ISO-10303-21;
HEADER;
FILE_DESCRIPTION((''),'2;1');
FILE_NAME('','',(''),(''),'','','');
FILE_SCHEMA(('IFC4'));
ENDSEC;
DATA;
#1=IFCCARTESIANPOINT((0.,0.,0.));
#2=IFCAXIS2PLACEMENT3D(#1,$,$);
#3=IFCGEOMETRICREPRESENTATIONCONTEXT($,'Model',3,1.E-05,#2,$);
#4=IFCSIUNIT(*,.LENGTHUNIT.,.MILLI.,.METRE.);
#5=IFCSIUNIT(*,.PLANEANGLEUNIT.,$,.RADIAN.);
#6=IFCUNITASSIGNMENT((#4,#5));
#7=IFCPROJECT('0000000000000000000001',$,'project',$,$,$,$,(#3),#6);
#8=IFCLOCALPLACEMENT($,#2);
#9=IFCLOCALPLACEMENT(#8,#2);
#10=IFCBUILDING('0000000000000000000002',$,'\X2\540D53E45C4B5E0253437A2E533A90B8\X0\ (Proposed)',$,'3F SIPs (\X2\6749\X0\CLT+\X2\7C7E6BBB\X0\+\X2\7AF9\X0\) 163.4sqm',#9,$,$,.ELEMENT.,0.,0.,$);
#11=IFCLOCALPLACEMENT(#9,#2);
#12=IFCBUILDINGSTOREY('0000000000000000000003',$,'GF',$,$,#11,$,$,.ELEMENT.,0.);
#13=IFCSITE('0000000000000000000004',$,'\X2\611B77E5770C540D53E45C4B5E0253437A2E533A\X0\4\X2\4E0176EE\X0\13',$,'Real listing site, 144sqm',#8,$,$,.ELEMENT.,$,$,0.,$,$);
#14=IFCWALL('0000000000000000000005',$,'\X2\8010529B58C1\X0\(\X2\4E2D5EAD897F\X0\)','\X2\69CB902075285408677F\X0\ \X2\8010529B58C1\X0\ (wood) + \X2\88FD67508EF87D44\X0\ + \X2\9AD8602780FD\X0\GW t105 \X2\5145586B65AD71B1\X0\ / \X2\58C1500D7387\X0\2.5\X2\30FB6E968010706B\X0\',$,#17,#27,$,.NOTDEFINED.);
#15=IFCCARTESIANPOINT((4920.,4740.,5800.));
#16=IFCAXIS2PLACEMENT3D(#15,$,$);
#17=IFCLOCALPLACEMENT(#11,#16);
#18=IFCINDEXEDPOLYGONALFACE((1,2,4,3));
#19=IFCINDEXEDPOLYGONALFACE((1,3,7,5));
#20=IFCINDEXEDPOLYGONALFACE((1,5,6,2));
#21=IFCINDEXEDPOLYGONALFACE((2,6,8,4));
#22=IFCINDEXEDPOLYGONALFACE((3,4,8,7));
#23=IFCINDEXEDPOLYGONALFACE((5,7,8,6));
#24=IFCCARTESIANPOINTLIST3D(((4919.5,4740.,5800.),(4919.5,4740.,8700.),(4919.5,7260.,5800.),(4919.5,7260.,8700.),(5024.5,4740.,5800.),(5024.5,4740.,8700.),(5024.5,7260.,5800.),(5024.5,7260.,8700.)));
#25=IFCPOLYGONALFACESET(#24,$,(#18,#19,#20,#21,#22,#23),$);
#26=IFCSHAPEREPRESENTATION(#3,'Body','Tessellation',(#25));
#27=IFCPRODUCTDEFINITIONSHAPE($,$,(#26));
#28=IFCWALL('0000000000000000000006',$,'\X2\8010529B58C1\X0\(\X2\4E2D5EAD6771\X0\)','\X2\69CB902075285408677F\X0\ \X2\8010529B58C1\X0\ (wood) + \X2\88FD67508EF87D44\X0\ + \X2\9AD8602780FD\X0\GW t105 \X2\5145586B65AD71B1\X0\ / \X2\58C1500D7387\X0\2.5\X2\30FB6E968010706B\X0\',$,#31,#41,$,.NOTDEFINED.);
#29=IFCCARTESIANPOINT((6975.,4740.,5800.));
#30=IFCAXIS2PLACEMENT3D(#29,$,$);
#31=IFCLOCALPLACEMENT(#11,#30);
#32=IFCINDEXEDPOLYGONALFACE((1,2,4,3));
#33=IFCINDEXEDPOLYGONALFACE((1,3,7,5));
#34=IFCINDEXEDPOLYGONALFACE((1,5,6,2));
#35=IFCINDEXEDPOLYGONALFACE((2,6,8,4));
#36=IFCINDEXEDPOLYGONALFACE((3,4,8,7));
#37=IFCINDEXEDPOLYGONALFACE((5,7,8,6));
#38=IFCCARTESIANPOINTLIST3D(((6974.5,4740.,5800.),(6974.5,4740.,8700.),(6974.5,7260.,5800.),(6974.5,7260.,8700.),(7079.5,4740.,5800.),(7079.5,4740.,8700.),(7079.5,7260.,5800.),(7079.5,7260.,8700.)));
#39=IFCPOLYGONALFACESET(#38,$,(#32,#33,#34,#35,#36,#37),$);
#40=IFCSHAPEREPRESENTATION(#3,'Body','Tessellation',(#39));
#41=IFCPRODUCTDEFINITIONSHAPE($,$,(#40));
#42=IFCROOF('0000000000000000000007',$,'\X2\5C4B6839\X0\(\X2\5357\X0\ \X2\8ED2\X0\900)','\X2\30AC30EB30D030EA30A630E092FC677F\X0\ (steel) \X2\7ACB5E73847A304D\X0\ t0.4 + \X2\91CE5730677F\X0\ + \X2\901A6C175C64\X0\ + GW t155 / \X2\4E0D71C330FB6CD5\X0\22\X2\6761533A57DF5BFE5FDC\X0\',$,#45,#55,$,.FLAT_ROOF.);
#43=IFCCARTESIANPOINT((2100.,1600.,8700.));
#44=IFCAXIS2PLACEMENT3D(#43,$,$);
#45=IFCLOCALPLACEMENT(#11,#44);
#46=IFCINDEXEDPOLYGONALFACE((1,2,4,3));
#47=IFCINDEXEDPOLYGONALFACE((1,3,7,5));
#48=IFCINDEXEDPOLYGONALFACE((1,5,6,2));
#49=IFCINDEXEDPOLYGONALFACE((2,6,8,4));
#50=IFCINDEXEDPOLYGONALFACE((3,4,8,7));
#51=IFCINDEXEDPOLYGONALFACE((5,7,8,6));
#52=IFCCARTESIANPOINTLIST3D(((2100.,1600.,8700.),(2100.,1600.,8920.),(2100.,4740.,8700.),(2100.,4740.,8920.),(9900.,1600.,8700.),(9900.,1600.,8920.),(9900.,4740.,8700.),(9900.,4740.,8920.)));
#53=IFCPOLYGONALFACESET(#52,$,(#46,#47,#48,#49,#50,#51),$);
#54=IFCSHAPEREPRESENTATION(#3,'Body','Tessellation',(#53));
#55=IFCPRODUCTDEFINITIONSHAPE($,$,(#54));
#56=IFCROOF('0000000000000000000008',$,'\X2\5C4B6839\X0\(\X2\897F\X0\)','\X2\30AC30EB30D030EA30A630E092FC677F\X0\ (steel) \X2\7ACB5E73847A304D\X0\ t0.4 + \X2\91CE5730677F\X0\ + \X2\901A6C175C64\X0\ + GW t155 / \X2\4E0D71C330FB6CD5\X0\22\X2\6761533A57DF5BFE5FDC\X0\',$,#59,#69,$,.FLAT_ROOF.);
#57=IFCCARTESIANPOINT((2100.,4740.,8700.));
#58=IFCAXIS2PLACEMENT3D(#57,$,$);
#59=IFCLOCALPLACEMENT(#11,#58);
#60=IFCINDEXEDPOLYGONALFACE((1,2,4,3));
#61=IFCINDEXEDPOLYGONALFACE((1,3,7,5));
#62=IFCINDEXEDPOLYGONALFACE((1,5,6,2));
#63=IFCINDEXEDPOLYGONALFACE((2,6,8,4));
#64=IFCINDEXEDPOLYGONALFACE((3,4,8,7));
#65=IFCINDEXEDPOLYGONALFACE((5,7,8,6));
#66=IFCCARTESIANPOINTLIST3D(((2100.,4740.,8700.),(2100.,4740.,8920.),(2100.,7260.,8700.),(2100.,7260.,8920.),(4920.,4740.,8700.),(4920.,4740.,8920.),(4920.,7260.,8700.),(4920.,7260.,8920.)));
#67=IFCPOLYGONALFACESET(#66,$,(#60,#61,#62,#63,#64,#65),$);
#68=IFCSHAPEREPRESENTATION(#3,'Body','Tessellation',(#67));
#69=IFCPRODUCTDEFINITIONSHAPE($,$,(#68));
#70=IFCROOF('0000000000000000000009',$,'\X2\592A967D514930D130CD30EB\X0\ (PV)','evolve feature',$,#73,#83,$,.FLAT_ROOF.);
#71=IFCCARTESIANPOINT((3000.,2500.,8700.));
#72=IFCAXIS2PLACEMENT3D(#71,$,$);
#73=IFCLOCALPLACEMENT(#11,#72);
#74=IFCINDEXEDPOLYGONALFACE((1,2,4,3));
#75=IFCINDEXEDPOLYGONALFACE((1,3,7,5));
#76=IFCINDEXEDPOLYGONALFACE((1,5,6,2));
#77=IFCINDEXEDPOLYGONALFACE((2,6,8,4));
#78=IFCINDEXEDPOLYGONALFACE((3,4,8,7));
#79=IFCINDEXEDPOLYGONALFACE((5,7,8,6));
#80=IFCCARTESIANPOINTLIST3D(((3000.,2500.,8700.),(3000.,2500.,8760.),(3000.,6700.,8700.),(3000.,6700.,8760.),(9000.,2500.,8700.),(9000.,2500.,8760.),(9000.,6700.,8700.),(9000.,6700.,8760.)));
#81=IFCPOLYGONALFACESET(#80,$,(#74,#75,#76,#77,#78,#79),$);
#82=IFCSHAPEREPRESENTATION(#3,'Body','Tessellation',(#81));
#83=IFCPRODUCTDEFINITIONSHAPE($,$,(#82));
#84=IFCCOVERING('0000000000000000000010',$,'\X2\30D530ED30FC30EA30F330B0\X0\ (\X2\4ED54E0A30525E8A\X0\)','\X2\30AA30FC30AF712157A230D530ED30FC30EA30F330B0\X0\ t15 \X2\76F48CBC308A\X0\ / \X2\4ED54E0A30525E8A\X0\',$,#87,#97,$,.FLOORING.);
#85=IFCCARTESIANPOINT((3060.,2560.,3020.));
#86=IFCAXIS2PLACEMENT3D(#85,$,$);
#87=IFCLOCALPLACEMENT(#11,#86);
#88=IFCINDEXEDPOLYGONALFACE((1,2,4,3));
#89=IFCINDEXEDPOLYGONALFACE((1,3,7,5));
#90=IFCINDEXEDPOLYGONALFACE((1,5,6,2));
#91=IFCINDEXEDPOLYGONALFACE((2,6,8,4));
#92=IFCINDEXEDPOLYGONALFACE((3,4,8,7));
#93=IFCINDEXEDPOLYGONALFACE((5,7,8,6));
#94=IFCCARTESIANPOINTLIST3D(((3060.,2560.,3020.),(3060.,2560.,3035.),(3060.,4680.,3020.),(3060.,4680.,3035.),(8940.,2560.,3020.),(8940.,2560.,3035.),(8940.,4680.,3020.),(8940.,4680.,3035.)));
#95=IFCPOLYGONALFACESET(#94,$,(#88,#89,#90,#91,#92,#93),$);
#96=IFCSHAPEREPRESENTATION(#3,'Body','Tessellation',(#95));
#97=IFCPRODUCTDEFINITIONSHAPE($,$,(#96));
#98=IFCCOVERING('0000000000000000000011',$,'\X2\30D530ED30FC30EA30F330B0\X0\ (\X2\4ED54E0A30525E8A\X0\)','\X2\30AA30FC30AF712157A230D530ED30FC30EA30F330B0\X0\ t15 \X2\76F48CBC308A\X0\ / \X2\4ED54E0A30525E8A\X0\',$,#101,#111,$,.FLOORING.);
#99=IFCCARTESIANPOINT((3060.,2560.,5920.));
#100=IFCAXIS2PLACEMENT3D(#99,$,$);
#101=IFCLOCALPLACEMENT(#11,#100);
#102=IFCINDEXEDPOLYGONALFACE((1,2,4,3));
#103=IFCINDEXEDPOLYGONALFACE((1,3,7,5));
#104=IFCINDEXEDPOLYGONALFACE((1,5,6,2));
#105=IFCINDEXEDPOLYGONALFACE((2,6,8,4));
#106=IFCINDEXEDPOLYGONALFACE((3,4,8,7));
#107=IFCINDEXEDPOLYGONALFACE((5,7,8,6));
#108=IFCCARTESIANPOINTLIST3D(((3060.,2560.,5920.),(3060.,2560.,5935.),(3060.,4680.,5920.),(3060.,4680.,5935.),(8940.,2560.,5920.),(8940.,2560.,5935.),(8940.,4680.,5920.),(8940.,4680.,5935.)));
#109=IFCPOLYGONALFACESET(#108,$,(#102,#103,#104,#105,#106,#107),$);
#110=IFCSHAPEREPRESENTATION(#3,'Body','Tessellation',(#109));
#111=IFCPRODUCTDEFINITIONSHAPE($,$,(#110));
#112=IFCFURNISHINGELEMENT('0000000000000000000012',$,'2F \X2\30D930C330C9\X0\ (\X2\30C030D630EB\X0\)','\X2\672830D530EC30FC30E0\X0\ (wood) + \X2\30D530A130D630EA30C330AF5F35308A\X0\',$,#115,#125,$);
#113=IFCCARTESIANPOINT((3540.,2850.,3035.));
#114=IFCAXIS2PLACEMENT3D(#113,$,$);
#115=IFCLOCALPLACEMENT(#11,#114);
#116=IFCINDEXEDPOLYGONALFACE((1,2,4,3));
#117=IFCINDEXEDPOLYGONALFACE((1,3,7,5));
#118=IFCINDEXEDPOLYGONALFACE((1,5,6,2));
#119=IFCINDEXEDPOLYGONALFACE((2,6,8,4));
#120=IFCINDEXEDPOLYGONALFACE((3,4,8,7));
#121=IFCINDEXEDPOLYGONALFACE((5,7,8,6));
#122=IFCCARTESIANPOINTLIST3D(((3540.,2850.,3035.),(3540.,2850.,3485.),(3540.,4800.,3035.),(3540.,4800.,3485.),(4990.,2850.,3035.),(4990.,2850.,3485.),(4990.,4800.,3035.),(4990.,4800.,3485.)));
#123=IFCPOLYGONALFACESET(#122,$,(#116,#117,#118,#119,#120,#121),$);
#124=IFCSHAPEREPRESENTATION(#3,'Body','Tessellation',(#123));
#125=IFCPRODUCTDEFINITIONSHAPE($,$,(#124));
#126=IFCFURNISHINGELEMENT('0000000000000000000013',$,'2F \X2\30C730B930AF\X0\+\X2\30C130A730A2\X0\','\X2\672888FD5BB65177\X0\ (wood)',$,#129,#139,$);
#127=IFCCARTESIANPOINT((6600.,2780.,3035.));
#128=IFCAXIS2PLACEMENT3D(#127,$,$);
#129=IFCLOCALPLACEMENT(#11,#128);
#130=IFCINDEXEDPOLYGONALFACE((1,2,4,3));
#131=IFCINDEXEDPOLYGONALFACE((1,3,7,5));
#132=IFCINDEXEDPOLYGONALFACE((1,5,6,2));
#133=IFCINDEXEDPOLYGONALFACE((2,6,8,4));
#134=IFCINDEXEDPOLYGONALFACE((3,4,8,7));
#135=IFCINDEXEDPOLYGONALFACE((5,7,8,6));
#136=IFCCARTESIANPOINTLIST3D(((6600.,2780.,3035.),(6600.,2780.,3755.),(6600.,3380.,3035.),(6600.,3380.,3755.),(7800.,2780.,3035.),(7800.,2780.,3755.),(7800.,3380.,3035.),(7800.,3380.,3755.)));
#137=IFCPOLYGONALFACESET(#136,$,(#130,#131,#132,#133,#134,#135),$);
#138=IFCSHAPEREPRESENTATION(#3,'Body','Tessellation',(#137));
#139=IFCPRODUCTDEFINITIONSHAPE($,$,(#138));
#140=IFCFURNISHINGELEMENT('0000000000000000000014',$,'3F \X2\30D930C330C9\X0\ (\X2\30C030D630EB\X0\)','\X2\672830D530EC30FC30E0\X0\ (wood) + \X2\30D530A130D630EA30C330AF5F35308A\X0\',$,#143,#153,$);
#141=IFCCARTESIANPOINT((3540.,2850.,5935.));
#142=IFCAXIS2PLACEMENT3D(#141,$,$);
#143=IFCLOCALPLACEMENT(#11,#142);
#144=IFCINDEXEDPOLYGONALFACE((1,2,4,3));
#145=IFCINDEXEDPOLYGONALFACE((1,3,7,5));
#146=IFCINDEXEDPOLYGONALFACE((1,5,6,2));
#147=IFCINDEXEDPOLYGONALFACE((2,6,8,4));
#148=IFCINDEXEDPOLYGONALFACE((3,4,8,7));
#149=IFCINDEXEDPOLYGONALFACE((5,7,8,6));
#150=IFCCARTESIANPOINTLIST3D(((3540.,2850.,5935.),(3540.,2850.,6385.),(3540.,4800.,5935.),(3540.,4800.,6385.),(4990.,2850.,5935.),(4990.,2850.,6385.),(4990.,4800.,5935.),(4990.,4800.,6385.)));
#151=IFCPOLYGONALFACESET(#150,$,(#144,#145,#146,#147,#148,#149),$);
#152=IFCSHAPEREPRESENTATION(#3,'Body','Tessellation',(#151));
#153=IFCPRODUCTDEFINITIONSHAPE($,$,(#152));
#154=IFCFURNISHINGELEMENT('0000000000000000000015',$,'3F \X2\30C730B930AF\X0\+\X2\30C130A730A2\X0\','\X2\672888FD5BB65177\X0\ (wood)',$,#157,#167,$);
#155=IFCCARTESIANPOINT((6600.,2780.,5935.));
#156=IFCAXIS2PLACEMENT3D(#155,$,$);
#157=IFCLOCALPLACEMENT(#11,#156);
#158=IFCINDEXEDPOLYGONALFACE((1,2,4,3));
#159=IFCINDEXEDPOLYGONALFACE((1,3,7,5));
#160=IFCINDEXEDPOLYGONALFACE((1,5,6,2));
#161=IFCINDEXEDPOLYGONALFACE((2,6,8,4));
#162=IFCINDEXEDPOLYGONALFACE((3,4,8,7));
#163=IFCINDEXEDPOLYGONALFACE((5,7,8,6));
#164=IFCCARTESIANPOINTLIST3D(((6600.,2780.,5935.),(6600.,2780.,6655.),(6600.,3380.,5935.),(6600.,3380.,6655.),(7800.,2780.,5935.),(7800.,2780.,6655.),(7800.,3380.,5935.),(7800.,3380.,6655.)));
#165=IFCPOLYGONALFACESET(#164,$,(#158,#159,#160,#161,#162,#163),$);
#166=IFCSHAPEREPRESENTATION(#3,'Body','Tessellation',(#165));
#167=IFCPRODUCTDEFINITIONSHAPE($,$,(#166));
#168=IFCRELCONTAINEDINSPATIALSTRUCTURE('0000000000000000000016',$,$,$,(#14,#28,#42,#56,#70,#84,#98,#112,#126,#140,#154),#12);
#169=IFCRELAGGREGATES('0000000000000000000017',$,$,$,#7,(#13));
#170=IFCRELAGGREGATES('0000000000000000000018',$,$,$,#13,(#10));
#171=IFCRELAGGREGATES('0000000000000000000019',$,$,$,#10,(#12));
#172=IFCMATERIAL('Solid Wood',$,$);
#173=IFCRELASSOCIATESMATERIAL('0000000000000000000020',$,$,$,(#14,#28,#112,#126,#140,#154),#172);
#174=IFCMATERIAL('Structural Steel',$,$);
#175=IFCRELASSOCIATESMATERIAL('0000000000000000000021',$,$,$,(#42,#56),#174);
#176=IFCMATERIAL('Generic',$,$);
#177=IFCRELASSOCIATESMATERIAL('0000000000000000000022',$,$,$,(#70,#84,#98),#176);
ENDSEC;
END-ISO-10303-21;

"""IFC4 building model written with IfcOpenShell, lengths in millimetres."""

from ifc_helpers import new_model, si_unit, frame, frame_2d, origin, place, context, project, spatial, rectangle, extrude, material, element, save


model = new_model("IFC4")

# Units and contexts
model_context = context("Model", 3, precision=1e-05, world=origin())
ifc_project = project(units=[si_unit("LENGTHUNIT", "METRE", prefix="MILLI"), si_unit("PLANEANGLEUNIT", "RADIAN")], contexts=[model_context])

# Site, building, storey
site_placement = place(None, origin())
site = spatial("IfcSite", under=ifc_project, at=site_placement, Name="愛知県名古屋市千種区4丁目13", ObjectType="Real listing site, 144sqm", CompositionType="ELEMENT", RefElevation=0.0)
building_placement = place(site_placement, origin())
building = spatial("IfcBuilding", under=site, at=building_placement, Name="名古屋市千種区邸 (Proposed)", ObjectType="3F SIPs (杉CLT+籾殻+竹) 163.4sqm", CompositionType="ELEMENT", ElevationOfRefHeight=0.0, ElevationOfTerrain=0.0)
storey_placement = place(building_placement, origin())
storey = spatial("IfcBuildingStorey", under=building, at=storey_placement, Name="GF", CompositionType="ELEMENT", Elevation=0.0)

# Shared definitions
ifc_material_1 = material(Name="Solid Wood")

# Walls
wall_1_placement = place(storey_placement, frame((4920.0, 4740.0, 5800.0)))
element("IfcWall", 1, at=wall_1_placement, inside=storey, material=ifc_material_1, Name="耐力壁(中庭西)", Description="構造用合板 耐力壁 (wood) + 製材軸組 + 高性能GW t105 充填断熱 / 壁倍率2.5・準耐火", PredefinedType="NOTDEFINED", context=model_context, shape_type="SweptSolid", body=[
    extrude(rectangle(XDim=105.0, YDim=2520.0, at=frame_2d((52.0, 1260.0))), frame((4920.0, 4740.0, 5800.0)), (0.0, 0.0, 1.0), 2900.0),
])
wall_2_placement = place(storey_placement, frame((6975.0, 4740.0, 5800.0)))
element("IfcWall", 2, at=wall_2_placement, inside=storey, material=ifc_material_1, Name="耐力壁(中庭東)", Description="構造用合板 耐力壁 (wood) + 製材軸組 + 高性能GW t105 充填断熱 / 壁倍率2.5・準耐火", PredefinedType="NOTDEFINED", context=model_context, shape_type="SweptSolid", body=[
    extrude(rectangle(XDim=105.0, YDim=2520.0, at=frame_2d((52.0, 1260.0))), frame((6975.0, 4740.0, 5800.0)), (0.0, 0.0, 1.0), 2900.0),
])

# Roofs
ifc_material_2 = material(Name="Structural Steel")
roof_1_placement = place(storey_placement, frame((2100.0, 1600.0, 8700.0)))
element("IfcRoof", 3, at=roof_1_placement, inside=storey, material=ifc_material_2, Name="屋根(南 軒900)", Description="ガルバリウム鋼板 (steel) 立平葺き t0.4 + 野地板 + 通気層 + GW t155 / 不燃・法22条区域対応", PredefinedType="FLAT_ROOF", context=model_context, shape_type="SweptSolid", body=[
    extrude(rectangle(XDim=7800.0, YDim=3140.0, at=frame_2d((3900.0, 1570.0))), frame((2100.0, 1600.0, 8700.0)), (0.0, 0.0, 1.0), 220.0),
])
roof_2_placement = place(storey_placement, frame((2100.0, 4740.0, 8700.0)))
element("IfcRoof", 4, at=roof_2_placement, inside=storey, material=ifc_material_2, Name="屋根(西)", Description="ガルバリウム鋼板 (steel) 立平葺き t0.4 + 野地板 + 通気層 + GW t155 / 不燃・法22条区域対応", PredefinedType="FLAT_ROOF", context=model_context, shape_type="SweptSolid", body=[
    extrude(rectangle(XDim=2820.0, YDim=2520.0, at=frame_2d((1410.0, 1260.0))), frame((2100.0, 4740.0, 8700.0)), (0.0, 0.0, 1.0), 220.0),
])
ifc_material_3 = material(Name="Generic")
roof_3_placement = place(storey_placement, frame((3000.0, 2500.0, 8700.0)))
element("IfcRoof", 5, at=roof_3_placement, inside=storey, material=ifc_material_3, Name="太陽光パネル (PV)", Description="evolve feature", PredefinedType="FLAT_ROOF", context=model_context, shape_type="SweptSolid", body=[
    extrude(rectangle(XDim=6000.0, YDim=4200.0, at=frame_2d((3000.0, 2100.0))), frame((3000.0, 2500.0, 8700.0)), (0.0, 0.0, 1.0), 60.0),
])

# Coverings
covering_1_placement = place(storey_placement, frame((3060.0, 2560.0, 3020.0)))
element("IfcCovering", 6, at=covering_1_placement, inside=storey, material=ifc_material_3, Name="フローリング (仕上げ床)", Description="オーク無垢フローリング t15 直貼り / 仕上げ床", PredefinedType="FLOORING", context=model_context, shape_type="SweptSolid", body=[
    extrude(rectangle(XDim=5880.0, YDim=2120.0, at=frame_2d((2940.0, 1060.0))), frame((3060.0, 2560.0, 3020.0)), (0.0, 0.0, 1.0), 15.0),
])
covering_2_placement = place(storey_placement, frame((3060.0, 2560.0, 5920.0)))
element("IfcCovering", 7, at=covering_2_placement, inside=storey, material=ifc_material_3, Name="フローリング (仕上げ床)", Description="オーク無垢フローリング t15 直貼り / 仕上げ床", PredefinedType="FLOORING", context=model_context, shape_type="SweptSolid", body=[
    extrude(rectangle(XDim=5880.0, YDim=2120.0, at=frame_2d((2940.0, 1060.0))), frame((3060.0, 2560.0, 5920.0)), (0.0, 0.0, 1.0), 15.0),
])

# Furnishing elements
furnishing_1_placement = place(storey_placement, frame((3540.0, 2850.0, 3035.0)))
element("IfcFurnishingElement", 8, at=furnishing_1_placement, inside=storey, material=ifc_material_1, Name="2F ベッド (ダブル)", Description="木フレーム (wood) + ファブリック張り", context=model_context, shape_type="SweptSolid", body=[
    extrude(rectangle(XDim=1450.0, YDim=1950.0, at=frame_2d((725.0, 975.0))), frame((3540.0, 2850.0, 3035.0)), (0.0, 0.0, 1.0), 450.0),
])
furnishing_2_placement = place(storey_placement, frame((6600.0, 2780.0, 3035.0)))
element("IfcFurnishingElement", 9, at=furnishing_2_placement, inside=storey, material=ifc_material_1, Name="2F デスク+チェア", Description="木製家具 (wood)", context=model_context, shape_type="SweptSolid", body=[
    extrude(rectangle(XDim=1200.0, YDim=600.0, at=frame_2d((600.0, 300.0))), frame((6600.0, 2780.0, 3035.0)), (0.0, 0.0, 1.0), 720.0),
])
furnishing_3_placement = place(storey_placement, frame((3540.0, 2850.0, 5935.0)))
element("IfcFurnishingElement", 10, at=furnishing_3_placement, inside=storey, material=ifc_material_1, Name="3F ベッド (ダブル)", Description="木フレーム (wood) + ファブリック張り", context=model_context, shape_type="SweptSolid", body=[
    extrude(rectangle(XDim=1450.0, YDim=1950.0, at=frame_2d((725.0, 975.0))), frame((3540.0, 2850.0, 5935.0)), (0.0, 0.0, 1.0), 450.0),
])
furnishing_4_placement = place(storey_placement, frame((6600.0, 2780.0, 5935.0)))
element("IfcFurnishingElement", 11, at=furnishing_4_placement, inside=storey, material=ifc_material_1, Name="3F デスク+チェア", Description="木製家具 (wood)", context=model_context, shape_type="SweptSolid", body=[
    extrude(rectangle(XDim=1200.0, YDim=600.0, at=frame_2d((600.0, 300.0))), frame((6600.0, 2780.0, 5935.0)), (0.0, 0.0, 1.0), 720.0),
])

save(model, "model.ifc")
